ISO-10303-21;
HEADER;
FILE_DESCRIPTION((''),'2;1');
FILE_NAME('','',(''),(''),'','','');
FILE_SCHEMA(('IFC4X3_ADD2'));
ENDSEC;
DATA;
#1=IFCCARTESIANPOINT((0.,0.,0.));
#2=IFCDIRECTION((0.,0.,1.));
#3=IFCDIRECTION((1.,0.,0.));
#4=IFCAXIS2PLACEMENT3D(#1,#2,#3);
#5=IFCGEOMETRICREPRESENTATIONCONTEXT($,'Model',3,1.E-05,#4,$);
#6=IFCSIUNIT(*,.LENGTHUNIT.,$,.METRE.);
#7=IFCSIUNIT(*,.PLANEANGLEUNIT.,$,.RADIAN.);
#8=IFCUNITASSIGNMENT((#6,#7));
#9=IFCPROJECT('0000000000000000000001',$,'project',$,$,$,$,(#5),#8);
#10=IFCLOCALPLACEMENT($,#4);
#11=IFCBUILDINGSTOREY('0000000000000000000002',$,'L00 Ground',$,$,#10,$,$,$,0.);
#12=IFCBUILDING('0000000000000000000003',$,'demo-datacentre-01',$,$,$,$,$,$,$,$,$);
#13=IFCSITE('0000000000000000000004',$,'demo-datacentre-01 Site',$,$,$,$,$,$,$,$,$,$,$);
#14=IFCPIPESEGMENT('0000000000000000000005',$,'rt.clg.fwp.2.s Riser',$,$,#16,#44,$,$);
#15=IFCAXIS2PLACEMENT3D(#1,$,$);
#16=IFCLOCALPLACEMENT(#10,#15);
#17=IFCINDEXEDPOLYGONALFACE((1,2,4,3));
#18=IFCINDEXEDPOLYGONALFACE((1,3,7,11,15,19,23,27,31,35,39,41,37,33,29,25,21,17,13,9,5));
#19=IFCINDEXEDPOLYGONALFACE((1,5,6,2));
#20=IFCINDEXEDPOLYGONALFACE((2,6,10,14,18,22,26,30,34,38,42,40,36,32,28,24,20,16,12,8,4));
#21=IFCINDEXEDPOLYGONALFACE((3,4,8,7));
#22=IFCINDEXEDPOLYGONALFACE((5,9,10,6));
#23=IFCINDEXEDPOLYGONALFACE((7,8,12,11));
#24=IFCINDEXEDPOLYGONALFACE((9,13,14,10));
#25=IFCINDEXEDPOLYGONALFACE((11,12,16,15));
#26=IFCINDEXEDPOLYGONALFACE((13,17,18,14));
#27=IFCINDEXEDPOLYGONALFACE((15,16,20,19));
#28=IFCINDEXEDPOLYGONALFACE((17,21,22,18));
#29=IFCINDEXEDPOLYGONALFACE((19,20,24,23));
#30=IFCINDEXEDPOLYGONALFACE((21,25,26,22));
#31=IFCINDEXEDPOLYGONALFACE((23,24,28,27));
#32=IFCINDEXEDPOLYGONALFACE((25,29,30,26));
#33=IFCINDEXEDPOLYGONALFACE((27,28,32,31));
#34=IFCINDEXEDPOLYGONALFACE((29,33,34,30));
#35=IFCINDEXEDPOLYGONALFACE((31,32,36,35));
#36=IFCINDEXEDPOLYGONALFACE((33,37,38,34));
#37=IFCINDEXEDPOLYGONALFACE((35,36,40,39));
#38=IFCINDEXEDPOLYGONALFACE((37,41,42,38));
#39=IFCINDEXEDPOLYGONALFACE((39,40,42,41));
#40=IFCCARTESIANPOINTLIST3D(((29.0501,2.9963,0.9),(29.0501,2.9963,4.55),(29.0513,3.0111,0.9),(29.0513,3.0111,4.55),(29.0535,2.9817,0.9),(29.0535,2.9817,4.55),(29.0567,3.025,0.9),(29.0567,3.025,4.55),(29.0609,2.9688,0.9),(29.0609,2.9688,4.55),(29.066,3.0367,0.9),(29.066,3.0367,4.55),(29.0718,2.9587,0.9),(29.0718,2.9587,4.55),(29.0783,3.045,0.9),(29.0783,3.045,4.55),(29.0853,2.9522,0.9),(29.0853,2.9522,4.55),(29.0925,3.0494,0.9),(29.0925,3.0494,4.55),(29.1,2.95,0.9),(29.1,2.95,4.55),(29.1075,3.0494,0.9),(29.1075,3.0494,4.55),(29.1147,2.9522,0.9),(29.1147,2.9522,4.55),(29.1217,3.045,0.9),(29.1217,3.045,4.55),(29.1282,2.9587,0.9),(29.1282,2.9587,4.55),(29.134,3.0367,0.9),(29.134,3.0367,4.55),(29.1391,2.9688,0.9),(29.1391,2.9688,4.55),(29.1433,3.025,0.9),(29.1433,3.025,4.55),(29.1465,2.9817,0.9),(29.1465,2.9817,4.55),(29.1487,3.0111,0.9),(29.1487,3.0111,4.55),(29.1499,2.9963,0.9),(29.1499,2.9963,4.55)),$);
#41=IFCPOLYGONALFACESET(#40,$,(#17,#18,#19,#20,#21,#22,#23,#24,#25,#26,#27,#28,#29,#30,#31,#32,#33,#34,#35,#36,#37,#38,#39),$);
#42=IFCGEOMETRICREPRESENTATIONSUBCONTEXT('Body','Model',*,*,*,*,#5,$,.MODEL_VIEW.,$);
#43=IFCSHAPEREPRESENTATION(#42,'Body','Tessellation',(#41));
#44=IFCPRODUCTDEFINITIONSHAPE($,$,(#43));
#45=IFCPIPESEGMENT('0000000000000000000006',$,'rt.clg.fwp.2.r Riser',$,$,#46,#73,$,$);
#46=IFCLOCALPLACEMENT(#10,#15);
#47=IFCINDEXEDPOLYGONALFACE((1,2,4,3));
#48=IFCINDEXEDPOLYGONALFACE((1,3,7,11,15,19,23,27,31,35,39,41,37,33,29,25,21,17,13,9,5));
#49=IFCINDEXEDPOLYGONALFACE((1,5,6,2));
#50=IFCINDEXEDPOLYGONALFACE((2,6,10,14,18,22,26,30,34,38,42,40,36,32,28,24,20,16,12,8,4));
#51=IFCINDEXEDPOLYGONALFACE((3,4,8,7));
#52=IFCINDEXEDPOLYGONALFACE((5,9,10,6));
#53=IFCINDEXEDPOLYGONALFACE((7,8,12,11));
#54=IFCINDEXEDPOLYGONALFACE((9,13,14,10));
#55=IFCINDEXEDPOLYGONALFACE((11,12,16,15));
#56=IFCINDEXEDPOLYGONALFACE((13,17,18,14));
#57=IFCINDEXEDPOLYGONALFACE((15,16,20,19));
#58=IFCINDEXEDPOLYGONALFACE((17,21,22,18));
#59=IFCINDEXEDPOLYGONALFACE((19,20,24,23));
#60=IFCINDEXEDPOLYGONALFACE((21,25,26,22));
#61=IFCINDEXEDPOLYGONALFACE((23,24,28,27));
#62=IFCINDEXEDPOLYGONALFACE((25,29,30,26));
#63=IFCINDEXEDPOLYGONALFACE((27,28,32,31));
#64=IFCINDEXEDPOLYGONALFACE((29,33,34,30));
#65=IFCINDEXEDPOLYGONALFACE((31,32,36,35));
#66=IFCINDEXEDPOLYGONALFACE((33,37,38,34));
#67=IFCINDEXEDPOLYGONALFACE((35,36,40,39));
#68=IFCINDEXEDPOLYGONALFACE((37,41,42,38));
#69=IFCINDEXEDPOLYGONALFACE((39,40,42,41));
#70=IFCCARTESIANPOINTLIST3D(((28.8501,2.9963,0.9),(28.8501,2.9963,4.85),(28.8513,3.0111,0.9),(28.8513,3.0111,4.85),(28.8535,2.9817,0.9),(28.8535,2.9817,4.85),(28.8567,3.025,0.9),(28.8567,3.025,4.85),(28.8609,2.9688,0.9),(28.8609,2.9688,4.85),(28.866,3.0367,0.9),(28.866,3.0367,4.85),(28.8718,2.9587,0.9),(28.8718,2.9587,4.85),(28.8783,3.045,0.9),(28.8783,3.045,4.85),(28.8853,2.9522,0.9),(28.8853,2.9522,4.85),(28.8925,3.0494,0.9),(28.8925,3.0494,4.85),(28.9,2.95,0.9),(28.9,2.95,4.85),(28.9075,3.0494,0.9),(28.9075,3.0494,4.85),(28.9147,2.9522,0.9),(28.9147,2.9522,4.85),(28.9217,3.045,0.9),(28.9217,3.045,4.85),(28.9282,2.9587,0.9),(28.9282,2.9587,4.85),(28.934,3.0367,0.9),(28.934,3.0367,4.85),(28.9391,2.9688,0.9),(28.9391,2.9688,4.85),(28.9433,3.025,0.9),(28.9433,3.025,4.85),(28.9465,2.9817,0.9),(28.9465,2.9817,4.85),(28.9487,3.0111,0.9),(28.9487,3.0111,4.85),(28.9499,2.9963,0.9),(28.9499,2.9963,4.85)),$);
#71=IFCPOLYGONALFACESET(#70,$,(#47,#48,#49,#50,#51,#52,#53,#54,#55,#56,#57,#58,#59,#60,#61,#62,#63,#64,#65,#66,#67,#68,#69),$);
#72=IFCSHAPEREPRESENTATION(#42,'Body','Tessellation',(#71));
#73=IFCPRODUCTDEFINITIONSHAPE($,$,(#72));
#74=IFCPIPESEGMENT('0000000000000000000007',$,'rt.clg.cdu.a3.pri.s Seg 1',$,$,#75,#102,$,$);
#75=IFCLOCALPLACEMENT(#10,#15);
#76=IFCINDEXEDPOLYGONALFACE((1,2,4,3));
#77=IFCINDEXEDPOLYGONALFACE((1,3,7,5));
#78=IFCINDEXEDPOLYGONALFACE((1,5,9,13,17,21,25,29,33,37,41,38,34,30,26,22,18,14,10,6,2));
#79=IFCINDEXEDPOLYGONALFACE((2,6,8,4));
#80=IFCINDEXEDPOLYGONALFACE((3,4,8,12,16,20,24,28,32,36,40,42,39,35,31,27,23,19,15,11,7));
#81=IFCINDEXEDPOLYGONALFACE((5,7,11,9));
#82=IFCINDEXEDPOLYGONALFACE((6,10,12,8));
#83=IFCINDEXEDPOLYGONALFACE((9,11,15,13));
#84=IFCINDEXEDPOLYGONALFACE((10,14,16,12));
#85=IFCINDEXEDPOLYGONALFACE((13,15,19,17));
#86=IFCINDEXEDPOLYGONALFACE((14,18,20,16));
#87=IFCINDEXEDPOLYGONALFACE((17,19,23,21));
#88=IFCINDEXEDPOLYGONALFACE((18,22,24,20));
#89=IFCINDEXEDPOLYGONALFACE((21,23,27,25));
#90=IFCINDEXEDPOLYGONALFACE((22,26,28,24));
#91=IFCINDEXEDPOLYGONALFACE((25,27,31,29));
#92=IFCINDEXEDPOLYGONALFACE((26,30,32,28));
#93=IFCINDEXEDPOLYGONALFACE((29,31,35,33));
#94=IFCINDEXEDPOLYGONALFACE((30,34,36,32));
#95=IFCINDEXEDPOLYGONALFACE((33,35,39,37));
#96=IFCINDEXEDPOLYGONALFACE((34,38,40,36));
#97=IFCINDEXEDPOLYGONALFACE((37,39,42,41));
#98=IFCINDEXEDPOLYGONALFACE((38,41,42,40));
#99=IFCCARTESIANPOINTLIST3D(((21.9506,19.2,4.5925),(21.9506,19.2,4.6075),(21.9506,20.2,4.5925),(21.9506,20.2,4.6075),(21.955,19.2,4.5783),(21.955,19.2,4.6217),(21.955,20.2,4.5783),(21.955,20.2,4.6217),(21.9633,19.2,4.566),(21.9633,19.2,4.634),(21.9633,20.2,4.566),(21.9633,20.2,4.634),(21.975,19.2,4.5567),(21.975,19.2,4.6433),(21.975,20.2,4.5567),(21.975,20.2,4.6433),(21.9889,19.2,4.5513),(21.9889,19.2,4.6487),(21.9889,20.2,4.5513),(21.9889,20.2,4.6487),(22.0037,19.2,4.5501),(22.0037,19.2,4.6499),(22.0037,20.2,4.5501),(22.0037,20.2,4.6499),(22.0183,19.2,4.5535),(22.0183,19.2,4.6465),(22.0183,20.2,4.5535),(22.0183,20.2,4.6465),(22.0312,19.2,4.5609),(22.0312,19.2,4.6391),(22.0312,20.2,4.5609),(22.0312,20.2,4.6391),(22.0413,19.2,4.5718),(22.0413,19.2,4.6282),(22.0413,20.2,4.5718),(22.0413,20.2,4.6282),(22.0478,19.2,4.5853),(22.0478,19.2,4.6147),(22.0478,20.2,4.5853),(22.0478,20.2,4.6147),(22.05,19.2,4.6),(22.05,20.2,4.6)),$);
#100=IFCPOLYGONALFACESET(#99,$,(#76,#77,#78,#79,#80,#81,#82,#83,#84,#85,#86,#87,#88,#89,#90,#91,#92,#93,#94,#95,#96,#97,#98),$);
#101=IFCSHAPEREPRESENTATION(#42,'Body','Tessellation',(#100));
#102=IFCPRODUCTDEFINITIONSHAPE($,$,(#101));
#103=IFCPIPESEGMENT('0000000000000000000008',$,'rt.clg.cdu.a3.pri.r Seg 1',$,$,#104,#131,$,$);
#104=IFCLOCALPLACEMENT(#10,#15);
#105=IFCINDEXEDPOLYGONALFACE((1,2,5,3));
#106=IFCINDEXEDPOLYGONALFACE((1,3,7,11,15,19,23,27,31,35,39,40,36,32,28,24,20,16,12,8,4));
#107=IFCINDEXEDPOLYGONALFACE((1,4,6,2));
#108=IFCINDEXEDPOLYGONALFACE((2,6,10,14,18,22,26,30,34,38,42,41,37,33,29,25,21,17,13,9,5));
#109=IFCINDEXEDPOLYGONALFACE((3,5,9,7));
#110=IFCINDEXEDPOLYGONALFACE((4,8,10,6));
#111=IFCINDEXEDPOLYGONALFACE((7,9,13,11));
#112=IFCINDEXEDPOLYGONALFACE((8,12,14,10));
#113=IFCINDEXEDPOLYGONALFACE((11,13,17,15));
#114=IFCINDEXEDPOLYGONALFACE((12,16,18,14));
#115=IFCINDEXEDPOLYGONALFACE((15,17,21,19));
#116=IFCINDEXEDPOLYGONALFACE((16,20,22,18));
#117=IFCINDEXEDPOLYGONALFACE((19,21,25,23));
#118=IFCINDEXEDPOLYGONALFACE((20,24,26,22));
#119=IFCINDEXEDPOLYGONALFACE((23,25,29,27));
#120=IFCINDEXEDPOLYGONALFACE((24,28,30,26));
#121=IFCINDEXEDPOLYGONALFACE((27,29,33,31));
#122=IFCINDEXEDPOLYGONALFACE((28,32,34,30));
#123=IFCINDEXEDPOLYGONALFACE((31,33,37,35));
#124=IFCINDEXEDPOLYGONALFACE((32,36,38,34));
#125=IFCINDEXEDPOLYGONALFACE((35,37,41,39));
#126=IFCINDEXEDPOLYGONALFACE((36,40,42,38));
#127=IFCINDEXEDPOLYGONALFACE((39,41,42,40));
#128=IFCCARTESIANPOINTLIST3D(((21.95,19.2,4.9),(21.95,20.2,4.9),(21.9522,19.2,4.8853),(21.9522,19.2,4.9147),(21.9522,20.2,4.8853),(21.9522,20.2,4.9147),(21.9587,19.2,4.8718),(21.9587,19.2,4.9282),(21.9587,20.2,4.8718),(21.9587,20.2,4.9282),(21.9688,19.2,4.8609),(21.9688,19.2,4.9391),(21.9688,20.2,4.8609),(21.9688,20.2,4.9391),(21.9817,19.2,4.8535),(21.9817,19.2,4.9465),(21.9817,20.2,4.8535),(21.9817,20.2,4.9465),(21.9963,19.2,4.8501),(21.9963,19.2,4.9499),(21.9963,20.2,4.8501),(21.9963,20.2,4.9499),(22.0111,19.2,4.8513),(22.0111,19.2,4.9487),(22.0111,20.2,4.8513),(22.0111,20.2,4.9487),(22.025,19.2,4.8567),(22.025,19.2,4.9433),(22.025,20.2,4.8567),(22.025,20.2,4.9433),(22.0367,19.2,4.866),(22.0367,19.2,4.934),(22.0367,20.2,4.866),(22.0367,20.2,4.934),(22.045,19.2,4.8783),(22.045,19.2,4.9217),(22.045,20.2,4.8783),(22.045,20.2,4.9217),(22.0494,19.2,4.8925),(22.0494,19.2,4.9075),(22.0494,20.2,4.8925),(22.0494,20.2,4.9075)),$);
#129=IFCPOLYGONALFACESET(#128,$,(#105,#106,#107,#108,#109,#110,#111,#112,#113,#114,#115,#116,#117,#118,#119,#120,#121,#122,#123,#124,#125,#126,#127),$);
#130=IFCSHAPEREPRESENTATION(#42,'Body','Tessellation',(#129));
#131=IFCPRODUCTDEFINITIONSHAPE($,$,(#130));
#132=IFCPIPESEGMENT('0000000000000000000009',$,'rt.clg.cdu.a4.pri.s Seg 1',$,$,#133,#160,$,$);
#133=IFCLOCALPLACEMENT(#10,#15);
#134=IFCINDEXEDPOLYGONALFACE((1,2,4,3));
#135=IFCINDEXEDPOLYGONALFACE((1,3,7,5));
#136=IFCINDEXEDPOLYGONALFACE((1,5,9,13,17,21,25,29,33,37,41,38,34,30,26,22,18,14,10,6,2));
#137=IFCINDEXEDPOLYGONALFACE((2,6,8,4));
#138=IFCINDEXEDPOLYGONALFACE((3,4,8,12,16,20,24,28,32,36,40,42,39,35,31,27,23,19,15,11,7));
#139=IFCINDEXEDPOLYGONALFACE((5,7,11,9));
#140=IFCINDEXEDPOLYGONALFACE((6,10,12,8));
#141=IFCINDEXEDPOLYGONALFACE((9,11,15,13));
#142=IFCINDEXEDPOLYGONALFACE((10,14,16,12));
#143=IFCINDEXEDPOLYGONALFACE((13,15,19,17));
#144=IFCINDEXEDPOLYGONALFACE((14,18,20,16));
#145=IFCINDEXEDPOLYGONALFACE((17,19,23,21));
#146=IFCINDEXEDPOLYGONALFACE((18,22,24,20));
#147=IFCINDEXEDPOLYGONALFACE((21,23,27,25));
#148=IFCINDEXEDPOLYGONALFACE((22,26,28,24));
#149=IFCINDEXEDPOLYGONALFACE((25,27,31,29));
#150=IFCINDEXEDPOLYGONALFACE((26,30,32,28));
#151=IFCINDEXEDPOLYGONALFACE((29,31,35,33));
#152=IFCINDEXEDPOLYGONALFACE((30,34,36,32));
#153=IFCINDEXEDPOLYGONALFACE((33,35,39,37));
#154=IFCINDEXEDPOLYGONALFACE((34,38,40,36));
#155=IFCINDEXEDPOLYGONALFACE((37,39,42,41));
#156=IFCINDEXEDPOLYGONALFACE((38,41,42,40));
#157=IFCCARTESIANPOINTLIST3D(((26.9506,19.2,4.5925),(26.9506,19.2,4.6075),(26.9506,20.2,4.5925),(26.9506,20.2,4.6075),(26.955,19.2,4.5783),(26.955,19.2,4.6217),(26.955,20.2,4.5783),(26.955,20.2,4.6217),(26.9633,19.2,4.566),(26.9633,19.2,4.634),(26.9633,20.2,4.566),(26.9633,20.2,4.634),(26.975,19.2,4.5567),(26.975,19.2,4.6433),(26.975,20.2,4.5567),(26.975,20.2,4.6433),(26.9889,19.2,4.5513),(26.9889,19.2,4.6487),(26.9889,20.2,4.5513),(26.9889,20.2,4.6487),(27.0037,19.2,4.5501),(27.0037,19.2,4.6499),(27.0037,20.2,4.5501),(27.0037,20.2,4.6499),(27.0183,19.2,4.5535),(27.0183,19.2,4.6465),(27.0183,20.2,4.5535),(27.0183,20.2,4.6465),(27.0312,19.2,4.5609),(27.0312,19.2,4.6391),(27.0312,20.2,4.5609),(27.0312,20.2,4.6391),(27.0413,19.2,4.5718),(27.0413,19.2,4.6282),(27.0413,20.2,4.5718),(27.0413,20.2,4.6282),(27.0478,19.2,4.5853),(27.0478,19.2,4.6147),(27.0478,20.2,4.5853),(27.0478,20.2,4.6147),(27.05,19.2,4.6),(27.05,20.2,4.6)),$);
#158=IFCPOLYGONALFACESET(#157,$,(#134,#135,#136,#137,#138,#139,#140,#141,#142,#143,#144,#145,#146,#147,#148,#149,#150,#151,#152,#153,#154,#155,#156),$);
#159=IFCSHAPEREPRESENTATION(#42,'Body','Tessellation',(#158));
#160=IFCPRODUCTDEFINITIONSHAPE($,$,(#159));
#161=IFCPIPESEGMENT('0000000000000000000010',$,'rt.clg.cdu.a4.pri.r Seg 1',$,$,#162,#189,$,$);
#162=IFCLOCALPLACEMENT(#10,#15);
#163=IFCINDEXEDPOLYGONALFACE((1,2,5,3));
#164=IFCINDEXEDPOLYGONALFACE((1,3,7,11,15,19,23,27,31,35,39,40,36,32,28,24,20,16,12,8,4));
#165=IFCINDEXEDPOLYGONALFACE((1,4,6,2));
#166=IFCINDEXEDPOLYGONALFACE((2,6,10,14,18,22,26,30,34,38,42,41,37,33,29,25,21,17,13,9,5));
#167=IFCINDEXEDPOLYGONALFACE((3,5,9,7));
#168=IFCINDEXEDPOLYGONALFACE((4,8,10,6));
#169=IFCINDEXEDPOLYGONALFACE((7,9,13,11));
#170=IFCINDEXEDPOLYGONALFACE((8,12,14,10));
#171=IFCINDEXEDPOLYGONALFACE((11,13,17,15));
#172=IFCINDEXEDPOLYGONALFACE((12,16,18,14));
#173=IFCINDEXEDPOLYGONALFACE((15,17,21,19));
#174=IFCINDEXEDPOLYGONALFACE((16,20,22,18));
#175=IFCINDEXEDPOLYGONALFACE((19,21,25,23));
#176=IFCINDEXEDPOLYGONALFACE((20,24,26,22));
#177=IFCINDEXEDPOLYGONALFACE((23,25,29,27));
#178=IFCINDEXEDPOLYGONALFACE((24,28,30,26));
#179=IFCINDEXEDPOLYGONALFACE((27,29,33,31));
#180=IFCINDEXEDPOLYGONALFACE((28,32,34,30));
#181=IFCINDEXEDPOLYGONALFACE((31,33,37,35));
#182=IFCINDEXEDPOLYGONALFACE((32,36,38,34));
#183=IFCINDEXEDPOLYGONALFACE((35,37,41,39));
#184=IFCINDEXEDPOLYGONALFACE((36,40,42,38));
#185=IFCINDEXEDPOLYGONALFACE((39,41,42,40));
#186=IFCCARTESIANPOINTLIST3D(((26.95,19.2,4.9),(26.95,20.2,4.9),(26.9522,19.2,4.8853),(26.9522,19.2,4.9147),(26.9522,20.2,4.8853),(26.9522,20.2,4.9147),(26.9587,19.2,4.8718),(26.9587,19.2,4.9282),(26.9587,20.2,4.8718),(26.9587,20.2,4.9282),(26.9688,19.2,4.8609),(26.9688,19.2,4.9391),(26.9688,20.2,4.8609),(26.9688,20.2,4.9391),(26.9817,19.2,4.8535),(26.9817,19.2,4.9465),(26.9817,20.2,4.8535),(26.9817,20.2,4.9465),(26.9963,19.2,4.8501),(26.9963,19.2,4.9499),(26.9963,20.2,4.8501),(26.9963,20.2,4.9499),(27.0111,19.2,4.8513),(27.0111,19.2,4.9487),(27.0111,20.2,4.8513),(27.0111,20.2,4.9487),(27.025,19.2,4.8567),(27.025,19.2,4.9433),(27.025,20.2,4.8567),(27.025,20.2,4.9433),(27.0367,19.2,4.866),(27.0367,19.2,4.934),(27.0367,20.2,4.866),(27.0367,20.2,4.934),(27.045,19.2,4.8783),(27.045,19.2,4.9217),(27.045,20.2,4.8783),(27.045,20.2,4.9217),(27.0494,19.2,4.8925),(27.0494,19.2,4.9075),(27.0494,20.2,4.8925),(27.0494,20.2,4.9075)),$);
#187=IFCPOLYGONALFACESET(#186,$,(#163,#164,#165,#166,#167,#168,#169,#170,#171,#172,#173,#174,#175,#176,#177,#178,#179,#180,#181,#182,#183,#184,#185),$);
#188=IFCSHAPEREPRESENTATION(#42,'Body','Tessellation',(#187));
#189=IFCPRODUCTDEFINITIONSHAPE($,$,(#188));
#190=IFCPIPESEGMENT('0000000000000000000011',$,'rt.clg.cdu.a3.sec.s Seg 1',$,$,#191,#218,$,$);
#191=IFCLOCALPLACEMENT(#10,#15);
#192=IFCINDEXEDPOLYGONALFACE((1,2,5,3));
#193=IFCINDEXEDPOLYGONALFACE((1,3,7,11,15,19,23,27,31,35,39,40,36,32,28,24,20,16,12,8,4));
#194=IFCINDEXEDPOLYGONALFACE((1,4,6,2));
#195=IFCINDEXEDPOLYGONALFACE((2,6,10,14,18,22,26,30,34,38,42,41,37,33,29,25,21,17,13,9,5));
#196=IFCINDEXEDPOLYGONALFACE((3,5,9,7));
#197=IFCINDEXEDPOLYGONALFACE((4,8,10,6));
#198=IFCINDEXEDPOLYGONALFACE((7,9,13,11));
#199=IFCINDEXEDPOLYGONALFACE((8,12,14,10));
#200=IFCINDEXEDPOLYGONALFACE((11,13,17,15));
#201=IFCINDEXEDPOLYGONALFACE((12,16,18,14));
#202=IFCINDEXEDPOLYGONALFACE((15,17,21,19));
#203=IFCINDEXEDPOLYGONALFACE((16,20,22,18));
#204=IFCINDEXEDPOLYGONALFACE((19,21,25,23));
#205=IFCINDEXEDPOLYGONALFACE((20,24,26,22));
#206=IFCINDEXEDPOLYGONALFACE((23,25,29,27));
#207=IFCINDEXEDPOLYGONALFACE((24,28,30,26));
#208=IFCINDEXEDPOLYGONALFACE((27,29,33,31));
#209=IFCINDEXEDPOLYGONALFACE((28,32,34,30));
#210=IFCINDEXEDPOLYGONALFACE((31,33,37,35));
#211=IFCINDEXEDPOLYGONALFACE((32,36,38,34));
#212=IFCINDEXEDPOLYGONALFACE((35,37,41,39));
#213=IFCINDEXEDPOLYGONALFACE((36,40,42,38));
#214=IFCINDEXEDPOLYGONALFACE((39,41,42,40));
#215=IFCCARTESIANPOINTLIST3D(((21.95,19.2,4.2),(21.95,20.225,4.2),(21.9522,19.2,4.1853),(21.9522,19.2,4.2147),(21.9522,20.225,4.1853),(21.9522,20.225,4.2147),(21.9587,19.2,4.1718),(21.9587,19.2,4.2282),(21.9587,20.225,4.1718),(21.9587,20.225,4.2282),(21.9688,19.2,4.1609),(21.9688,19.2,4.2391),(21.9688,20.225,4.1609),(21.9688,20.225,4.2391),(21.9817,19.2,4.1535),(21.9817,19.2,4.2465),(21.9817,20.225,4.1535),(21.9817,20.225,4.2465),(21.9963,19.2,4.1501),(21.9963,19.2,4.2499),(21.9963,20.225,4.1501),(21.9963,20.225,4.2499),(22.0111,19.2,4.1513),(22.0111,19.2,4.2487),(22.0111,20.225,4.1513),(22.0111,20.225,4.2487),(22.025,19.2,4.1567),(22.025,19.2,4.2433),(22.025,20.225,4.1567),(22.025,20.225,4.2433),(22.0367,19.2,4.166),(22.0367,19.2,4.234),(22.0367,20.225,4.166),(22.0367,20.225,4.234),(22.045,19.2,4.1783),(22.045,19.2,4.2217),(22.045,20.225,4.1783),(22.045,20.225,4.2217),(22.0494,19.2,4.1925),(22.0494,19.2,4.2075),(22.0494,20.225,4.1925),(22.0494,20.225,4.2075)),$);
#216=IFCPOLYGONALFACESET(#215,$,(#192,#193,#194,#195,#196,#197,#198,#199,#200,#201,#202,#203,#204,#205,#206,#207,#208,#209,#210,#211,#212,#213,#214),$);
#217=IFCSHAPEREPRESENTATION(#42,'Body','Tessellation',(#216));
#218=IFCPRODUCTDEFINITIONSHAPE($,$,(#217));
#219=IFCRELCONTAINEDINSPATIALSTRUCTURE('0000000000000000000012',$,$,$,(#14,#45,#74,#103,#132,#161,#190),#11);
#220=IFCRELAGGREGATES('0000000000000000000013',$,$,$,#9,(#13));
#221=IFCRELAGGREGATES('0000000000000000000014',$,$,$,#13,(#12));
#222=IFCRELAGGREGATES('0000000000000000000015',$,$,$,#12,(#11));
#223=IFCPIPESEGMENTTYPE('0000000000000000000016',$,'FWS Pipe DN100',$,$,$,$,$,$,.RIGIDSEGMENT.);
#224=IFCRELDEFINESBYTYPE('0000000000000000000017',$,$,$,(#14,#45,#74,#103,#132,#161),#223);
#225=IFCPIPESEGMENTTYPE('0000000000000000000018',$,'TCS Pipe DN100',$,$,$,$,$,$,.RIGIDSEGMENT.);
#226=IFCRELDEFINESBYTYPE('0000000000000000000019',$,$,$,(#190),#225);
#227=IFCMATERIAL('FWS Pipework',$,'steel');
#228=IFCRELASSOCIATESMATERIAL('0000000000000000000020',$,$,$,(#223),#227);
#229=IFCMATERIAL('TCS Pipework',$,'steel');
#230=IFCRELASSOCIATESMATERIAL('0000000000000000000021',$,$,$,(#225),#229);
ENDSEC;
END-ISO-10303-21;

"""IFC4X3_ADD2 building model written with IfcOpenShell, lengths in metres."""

from ifc_helpers import new_model, si_unit, frame, origin_with_axes, place, context, subcontext, project, spatial, circle, extrude, material, type_object, element, save


model = new_model("IFC4X3_ADD2")

# Units and contexts
model_context = context("Model", 3, precision=1e-05, world=origin_with_axes())
body_context = subcontext(model_context, "Body", "Model", "MODEL_VIEW")
ifc_project = project(units=[si_unit("LENGTHUNIT", "METRE"), si_unit("PLANEANGLEUNIT", "RADIAN")], contexts=[model_context])

# Site, building, storey
site = spatial("IfcSite", under=ifc_project, Name="demo-datacentre-01 Site")
building = spatial("IfcBuilding", under=site, Name="demo-datacentre-01")
storey_placement = place(None, origin_with_axes())
storey = spatial("IfcBuildingStorey", under=building, at=storey_placement, Name="L00 Ground", Elevation=0.0)

# Shared definitions
ifc_material_1 = material(Name="FWS Pipework", Category="steel")

# Pipe segments
pipe_segment_type_1 = type_object("IfcPipeSegmentType", Name="FWS Pipe DN100", PredefinedType="RIGIDSEGMENT", material=ifc_material_1)
pipe_segment_1_placement = place(storey_placement, frame((29.1, 3.0, 0.9), z_axis=(0.0, 0.0, 1.0), x_axis=(0.0, -1.0, 0.0)))
element("IfcPipeSegment", 1, at=pipe_segment_1_placement, inside=storey, type_object=pipe_segment_type_1, Name="rt.clg.fwp.2.s Riser", context=body_context, shape_type="SweptSolid", body=[
    extrude(circle(Radius=0.05), origin_with_axes(), (0.0, 0.0, 1.0), 3.65),
])
pipe_segment_2_placement = place(storey_placement, frame((28.9, 3.0, 0.9), z_axis=(0.0, 0.0, 1.0), x_axis=(0.0, -1.0, 0.0)))
element("IfcPipeSegment", 2, at=pipe_segment_2_placement, inside=storey, type_object=pipe_segment_type_1, Name="rt.clg.fwp.2.r Riser", context=body_context, shape_type="SweptSolid", body=[
    extrude(circle(Radius=0.05), origin_with_axes(), (0.0, 0.0, 1.0), 3.95),
])
for number, where, z_axis, x_axis, name in (
    (3, (22.0, 20.2, 4.6), (0.0, -1.0, 0.0), (1.0, 0.0, 0.0), "rt.clg.cdu.a3.pri.s Seg 1"),
    (4, (22.0, 19.2, 4.9), (0.0, 1.0, 0.0), (-1.0, 0.0, 0.0), "rt.clg.cdu.a3.pri.r Seg 1"),
    (5, (27.0, 20.2, 4.6), (0.0, -1.0, 0.0), (1.0, 0.0, 0.0), "rt.clg.cdu.a4.pri.s Seg 1"),
    (6, (27.0, 19.2, 4.9), (0.0, 1.0, 0.0), (-1.0, 0.0, 0.0), "rt.clg.cdu.a4.pri.r Seg 1"),
):
    element("IfcPipeSegment", number, at=place(storey_placement, frame(where, z_axis=z_axis, x_axis=x_axis)), inside=storey, type_object=pipe_segment_type_1, Name=name, context=body_context, shape_type="SweptSolid", body=[
        extrude(circle(Radius=0.05), origin_with_axes(), (0.0, 0.0, 1.0), 1.0),
    ])
ifc_material_2 = material(Name="TCS Pipework", Category="steel")
pipe_segment_type_2 = type_object("IfcPipeSegmentType", Name="TCS Pipe DN100", PredefinedType="RIGIDSEGMENT", material=ifc_material_2)
pipe_segment_3_placement = place(storey_placement, frame((22.0, 19.2, 4.2), z_axis=(0.0, 1.0, 0.0), x_axis=(-1.0, 0.0, 0.0)))
element("IfcPipeSegment", 7, at=pipe_segment_3_placement, inside=storey, type_object=pipe_segment_type_2, Name="rt.clg.cdu.a3.sec.s Seg 1", context=body_context, shape_type="SweptSolid", body=[
    extrude(circle(Radius=0.05), origin_with_axes(), (0.0, 0.0, 1.0), 1.025),
])

save(model, "model.ifc")
